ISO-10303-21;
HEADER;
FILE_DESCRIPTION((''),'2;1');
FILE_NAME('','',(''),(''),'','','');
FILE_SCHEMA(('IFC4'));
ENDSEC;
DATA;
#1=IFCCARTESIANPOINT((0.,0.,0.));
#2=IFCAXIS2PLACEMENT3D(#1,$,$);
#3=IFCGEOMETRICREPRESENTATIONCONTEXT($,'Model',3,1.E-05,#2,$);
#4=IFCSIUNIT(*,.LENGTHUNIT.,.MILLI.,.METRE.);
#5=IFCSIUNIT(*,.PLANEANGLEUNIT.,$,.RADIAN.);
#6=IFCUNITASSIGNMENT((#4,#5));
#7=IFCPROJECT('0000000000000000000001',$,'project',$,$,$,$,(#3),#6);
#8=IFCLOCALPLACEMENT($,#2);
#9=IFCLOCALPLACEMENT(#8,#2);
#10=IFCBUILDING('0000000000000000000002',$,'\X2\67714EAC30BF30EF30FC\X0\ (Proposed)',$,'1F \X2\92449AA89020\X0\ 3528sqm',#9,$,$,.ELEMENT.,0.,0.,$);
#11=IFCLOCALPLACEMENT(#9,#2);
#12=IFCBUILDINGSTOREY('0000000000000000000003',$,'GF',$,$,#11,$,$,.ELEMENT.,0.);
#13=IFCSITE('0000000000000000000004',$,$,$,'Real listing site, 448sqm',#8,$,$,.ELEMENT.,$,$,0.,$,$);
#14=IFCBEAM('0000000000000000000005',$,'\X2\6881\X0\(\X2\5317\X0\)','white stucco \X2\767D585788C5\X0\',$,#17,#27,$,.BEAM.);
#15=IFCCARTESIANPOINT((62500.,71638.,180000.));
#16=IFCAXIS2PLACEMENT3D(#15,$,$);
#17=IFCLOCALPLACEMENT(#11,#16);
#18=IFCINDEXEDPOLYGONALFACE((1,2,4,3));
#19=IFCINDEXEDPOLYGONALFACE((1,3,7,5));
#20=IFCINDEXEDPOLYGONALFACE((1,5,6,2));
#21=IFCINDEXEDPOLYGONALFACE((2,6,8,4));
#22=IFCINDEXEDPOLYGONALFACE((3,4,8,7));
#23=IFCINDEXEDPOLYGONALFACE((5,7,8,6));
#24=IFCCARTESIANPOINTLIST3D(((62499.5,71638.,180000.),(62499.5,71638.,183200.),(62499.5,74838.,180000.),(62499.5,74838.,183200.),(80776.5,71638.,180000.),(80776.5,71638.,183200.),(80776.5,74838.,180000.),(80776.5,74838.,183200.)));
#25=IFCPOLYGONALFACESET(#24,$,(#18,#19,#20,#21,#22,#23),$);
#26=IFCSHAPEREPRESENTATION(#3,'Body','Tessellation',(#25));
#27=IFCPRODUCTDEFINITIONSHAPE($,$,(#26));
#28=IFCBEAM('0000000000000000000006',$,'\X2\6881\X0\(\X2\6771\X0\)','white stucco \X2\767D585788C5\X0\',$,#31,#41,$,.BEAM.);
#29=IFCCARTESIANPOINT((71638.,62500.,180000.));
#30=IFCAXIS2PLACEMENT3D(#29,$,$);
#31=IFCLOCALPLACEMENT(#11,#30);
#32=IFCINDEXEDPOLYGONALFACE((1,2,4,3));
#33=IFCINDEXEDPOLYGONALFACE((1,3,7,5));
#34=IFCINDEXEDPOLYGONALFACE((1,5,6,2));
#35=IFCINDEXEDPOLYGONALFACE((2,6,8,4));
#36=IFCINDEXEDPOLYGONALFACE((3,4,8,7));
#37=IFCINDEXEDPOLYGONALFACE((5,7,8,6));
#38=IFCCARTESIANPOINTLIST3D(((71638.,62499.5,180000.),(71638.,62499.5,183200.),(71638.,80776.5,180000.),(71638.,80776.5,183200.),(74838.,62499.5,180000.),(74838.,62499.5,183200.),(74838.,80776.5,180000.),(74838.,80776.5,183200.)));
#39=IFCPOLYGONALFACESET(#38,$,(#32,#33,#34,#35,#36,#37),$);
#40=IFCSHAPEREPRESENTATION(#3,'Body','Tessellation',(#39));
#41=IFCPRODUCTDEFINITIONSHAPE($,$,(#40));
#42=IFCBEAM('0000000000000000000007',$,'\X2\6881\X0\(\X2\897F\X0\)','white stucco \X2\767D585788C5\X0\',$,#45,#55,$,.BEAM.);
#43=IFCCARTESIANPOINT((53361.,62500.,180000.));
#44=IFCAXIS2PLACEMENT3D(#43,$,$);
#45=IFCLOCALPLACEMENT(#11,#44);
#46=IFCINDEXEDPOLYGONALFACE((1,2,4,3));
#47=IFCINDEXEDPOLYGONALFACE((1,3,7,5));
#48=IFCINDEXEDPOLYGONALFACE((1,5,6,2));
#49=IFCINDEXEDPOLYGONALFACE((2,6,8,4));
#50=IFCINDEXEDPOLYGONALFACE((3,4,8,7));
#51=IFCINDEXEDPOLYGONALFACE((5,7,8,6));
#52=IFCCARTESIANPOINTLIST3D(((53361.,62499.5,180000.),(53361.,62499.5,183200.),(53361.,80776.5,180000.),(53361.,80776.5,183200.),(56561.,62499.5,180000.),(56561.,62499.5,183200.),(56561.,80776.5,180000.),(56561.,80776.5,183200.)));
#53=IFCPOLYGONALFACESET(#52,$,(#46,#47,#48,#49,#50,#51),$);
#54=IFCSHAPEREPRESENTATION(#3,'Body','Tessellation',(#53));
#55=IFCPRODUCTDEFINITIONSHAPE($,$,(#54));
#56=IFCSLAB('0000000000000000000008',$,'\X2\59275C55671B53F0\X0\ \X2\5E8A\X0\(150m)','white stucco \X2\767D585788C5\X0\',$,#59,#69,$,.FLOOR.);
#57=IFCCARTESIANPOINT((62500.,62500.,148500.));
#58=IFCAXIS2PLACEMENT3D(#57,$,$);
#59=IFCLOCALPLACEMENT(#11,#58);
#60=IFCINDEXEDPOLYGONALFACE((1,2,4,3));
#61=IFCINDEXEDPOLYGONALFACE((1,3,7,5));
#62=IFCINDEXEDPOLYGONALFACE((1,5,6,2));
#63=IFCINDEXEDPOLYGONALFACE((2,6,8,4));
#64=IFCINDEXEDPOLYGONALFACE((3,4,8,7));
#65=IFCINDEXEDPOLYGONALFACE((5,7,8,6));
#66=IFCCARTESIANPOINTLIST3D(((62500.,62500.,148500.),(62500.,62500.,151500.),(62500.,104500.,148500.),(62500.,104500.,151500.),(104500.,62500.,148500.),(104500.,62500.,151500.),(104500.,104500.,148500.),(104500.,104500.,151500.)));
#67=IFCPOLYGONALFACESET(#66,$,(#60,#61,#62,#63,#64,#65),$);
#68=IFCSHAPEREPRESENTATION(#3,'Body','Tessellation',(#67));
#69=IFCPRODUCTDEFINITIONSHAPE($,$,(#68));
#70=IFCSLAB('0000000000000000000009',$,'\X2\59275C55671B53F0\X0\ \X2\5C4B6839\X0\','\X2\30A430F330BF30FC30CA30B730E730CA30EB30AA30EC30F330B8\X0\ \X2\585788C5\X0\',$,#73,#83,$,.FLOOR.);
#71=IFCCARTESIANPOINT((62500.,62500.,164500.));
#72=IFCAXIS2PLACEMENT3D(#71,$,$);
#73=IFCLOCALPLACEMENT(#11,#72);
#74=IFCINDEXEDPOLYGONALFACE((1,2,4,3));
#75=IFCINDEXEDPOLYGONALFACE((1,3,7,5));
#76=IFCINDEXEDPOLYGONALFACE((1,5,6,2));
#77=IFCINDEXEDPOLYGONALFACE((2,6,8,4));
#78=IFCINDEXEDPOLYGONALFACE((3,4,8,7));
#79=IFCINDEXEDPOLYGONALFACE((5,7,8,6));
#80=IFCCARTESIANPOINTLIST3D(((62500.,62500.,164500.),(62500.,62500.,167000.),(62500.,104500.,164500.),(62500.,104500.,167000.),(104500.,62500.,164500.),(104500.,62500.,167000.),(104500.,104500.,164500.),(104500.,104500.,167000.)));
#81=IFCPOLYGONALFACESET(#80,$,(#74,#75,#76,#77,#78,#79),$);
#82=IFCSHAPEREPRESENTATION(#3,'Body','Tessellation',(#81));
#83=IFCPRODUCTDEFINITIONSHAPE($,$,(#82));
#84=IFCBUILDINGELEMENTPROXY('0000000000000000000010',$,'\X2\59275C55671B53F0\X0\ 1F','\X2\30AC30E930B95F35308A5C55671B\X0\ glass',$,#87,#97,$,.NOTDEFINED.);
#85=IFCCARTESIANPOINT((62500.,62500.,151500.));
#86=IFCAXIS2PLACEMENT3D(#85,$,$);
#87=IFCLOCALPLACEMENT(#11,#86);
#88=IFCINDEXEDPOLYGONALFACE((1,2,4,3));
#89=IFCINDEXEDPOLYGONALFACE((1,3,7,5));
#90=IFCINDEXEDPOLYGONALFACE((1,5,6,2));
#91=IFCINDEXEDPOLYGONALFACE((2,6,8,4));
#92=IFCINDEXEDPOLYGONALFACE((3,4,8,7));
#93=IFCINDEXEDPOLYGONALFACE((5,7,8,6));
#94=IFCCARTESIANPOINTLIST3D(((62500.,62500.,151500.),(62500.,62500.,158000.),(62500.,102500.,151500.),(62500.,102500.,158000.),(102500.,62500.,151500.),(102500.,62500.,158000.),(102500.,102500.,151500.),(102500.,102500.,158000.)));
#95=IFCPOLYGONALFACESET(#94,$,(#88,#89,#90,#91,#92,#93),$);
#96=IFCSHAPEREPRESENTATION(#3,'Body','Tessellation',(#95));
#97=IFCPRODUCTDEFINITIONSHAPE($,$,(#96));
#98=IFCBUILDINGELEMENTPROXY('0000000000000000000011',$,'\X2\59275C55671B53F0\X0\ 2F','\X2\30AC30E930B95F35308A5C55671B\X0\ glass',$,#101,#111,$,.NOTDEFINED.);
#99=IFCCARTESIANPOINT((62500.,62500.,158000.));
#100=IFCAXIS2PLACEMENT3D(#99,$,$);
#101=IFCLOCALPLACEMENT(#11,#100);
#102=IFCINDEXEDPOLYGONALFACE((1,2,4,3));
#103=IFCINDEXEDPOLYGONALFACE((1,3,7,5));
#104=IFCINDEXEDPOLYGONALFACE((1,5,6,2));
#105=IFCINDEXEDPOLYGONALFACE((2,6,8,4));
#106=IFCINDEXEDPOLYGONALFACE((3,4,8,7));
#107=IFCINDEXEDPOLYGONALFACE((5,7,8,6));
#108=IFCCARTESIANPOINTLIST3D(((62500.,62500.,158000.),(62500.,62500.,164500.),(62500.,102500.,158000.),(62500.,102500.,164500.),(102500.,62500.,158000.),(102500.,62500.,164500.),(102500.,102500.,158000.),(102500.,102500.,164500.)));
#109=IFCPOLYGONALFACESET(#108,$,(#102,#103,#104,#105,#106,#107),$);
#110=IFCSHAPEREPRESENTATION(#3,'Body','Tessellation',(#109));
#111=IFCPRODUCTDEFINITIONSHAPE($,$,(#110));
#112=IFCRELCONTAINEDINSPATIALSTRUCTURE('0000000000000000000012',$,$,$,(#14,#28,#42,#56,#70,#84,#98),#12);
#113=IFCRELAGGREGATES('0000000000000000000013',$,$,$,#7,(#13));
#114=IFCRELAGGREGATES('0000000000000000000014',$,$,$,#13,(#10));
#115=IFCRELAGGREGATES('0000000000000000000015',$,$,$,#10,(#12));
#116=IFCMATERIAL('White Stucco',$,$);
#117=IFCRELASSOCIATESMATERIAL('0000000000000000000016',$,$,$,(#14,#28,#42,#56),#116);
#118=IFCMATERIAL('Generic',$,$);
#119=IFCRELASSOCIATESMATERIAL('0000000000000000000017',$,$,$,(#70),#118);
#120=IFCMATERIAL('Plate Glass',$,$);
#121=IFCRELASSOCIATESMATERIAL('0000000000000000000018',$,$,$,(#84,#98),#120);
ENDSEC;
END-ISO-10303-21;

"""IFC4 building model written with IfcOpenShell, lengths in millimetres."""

from ifc_helpers import new_model, si_unit, frame, frame_2d, origin, place, context, project, spatial, rectangle, extrude, material, element, save


model = new_model("IFC4")

# Units and contexts
model_context = context("Model", 3, precision=1e-05, world=origin())
ifc_project = project(units=[si_unit("LENGTHUNIT", "METRE", prefix="MILLI"), si_unit("PLANEANGLEUNIT", "RADIAN")], contexts=[model_context])

# Site, building, storey
site_placement = place(None, origin())
site = spatial("IfcSite", under=ifc_project, at=site_placement, ObjectType="Real listing site, 448sqm", CompositionType="ELEMENT", RefElevation=0.0)
building_placement = place(site_placement, origin())
building = spatial("IfcBuilding", under=site, at=building_placement, Name="東京タワー (Proposed)", ObjectType="1F 鉄骨造 3528sqm", CompositionType="ELEMENT", ElevationOfRefHeight=0.0, ElevationOfTerrain=0.0)
storey_placement = place(building_placement, origin())
storey = spatial("IfcBuildingStorey", under=building, at=storey_placement, Name="GF", CompositionType="ELEMENT", Elevation=0.0)

# Shared definitions
ifc_material_1 = material(Name="White Stucco")
ifc_material_2 = material(Name="Generic")

# Beams
beam_1_placement = place(storey_placement, frame((62500.0, 71638.0, 180000.0)))
element("IfcBeam", 1, at=beam_1_placement, inside=storey, material=ifc_material_1, Name="梁(北)", Description="white stucco 白塗装", PredefinedType="BEAM", context=model_context, shape_type="SweptSolid", body=[
    extrude(rectangle(XDim=18277.0, YDim=3200.0, at=frame_2d((9138.0, 1600.0))), frame((62500.0, 71638.0, 180000.0)), (0.0, 0.0, 1.0), 3200.0),
])
beam_2_placement = place(storey_placement, frame((71638.0, 62500.0, 180000.0)))
element("IfcBeam", 2, at=beam_2_placement, inside=storey, material=ifc_material_1, Name="梁(東)", Description="white stucco 白塗装", PredefinedType="BEAM", context=model_context, shape_type="SweptSolid", body=[
    extrude(rectangle(XDim=3200.0, YDim=18277.0, at=frame_2d((1600.0, 9138.0))), frame((71638.0, 62500.0, 180000.0)), (0.0, 0.0, 1.0), 3200.0),
])
beam_3_placement = place(storey_placement, frame((53361.0, 62500.0, 180000.0)))
element("IfcBeam", 3, at=beam_3_placement, inside=storey, material=ifc_material_1, Name="梁(西)", Description="white stucco 白塗装", PredefinedType="BEAM", context=model_context, shape_type="SweptSolid", body=[
    extrude(rectangle(XDim=3200.0, YDim=18277.0, at=frame_2d((1600.0, 9138.0))), frame((53361.0, 62500.0, 180000.0)), (0.0, 0.0, 1.0), 3200.0),
])

# Slabs
slab_1_placement = place(storey_placement, frame((62500.0, 62500.0, 148500.0)))
element("IfcSlab", 4, at=slab_1_placement, inside=storey, material=ifc_material_1, Name="大展望台 床(150m)", Description="white stucco 白塗装", PredefinedType="FLOOR", context=model_context, shape_type="SweptSolid", body=[
    extrude(rectangle(XDim=42000.0, YDim=42000.0, at=frame_2d((21000.0, 21000.0))), frame((62500.0, 62500.0, 148500.0)), (0.0, 0.0, 1.0), 3000.0),
])
slab_2_placement = place(storey_placement, frame((62500.0, 62500.0, 164500.0)))
element("IfcSlab", 5, at=slab_2_placement, inside=storey, material=ifc_material_2, Name="大展望台 屋根", Description="インターナショナルオレンジ 塗装", PredefinedType="FLOOR", context=model_context, shape_type="SweptSolid", body=[
    extrude(rectangle(XDim=42000.0, YDim=42000.0, at=frame_2d((21000.0, 21000.0))), frame((62500.0, 62500.0, 164500.0)), (0.0, 0.0, 1.0), 2500.0),
])

# Building element proxies
ifc_material_3 = material(Name="Plate Glass")
proxy_1_placement = place(storey_placement, frame((62500.0, 62500.0, 151500.0)))
element("IfcBuildingElementProxy", 6, at=proxy_1_placement, inside=storey, material=ifc_material_3, Name="大展望台 1F", Description="ガラス張り展望 glass", PredefinedType="NOTDEFINED", context=model_context, shape_type="SweptSolid", body=[
    extrude(rectangle(XDim=40000.0, YDim=40000.0, at=frame_2d((20000.0, 20000.0))), frame((62500.0, 62500.0, 151500.0)), (0.0, 0.0, 1.0), 6500.0),
])
proxy_2_placement = place(storey_placement, frame((62500.0, 62500.0, 158000.0)))
element("IfcBuildingElementProxy", 7, at=proxy_2_placement, inside=storey, material=ifc_material_3, Name="大展望台 2F", Description="ガラス張り展望 glass", PredefinedType="NOTDEFINED", context=model_context, shape_type="SweptSolid", body=[
    extrude(rectangle(XDim=40000.0, YDim=40000.0, at=frame_2d((20000.0, 20000.0))), frame((62500.0, 62500.0, 158000.0)), (0.0, 0.0, 1.0), 6500.0),
])

save(model, "model.ifc")
